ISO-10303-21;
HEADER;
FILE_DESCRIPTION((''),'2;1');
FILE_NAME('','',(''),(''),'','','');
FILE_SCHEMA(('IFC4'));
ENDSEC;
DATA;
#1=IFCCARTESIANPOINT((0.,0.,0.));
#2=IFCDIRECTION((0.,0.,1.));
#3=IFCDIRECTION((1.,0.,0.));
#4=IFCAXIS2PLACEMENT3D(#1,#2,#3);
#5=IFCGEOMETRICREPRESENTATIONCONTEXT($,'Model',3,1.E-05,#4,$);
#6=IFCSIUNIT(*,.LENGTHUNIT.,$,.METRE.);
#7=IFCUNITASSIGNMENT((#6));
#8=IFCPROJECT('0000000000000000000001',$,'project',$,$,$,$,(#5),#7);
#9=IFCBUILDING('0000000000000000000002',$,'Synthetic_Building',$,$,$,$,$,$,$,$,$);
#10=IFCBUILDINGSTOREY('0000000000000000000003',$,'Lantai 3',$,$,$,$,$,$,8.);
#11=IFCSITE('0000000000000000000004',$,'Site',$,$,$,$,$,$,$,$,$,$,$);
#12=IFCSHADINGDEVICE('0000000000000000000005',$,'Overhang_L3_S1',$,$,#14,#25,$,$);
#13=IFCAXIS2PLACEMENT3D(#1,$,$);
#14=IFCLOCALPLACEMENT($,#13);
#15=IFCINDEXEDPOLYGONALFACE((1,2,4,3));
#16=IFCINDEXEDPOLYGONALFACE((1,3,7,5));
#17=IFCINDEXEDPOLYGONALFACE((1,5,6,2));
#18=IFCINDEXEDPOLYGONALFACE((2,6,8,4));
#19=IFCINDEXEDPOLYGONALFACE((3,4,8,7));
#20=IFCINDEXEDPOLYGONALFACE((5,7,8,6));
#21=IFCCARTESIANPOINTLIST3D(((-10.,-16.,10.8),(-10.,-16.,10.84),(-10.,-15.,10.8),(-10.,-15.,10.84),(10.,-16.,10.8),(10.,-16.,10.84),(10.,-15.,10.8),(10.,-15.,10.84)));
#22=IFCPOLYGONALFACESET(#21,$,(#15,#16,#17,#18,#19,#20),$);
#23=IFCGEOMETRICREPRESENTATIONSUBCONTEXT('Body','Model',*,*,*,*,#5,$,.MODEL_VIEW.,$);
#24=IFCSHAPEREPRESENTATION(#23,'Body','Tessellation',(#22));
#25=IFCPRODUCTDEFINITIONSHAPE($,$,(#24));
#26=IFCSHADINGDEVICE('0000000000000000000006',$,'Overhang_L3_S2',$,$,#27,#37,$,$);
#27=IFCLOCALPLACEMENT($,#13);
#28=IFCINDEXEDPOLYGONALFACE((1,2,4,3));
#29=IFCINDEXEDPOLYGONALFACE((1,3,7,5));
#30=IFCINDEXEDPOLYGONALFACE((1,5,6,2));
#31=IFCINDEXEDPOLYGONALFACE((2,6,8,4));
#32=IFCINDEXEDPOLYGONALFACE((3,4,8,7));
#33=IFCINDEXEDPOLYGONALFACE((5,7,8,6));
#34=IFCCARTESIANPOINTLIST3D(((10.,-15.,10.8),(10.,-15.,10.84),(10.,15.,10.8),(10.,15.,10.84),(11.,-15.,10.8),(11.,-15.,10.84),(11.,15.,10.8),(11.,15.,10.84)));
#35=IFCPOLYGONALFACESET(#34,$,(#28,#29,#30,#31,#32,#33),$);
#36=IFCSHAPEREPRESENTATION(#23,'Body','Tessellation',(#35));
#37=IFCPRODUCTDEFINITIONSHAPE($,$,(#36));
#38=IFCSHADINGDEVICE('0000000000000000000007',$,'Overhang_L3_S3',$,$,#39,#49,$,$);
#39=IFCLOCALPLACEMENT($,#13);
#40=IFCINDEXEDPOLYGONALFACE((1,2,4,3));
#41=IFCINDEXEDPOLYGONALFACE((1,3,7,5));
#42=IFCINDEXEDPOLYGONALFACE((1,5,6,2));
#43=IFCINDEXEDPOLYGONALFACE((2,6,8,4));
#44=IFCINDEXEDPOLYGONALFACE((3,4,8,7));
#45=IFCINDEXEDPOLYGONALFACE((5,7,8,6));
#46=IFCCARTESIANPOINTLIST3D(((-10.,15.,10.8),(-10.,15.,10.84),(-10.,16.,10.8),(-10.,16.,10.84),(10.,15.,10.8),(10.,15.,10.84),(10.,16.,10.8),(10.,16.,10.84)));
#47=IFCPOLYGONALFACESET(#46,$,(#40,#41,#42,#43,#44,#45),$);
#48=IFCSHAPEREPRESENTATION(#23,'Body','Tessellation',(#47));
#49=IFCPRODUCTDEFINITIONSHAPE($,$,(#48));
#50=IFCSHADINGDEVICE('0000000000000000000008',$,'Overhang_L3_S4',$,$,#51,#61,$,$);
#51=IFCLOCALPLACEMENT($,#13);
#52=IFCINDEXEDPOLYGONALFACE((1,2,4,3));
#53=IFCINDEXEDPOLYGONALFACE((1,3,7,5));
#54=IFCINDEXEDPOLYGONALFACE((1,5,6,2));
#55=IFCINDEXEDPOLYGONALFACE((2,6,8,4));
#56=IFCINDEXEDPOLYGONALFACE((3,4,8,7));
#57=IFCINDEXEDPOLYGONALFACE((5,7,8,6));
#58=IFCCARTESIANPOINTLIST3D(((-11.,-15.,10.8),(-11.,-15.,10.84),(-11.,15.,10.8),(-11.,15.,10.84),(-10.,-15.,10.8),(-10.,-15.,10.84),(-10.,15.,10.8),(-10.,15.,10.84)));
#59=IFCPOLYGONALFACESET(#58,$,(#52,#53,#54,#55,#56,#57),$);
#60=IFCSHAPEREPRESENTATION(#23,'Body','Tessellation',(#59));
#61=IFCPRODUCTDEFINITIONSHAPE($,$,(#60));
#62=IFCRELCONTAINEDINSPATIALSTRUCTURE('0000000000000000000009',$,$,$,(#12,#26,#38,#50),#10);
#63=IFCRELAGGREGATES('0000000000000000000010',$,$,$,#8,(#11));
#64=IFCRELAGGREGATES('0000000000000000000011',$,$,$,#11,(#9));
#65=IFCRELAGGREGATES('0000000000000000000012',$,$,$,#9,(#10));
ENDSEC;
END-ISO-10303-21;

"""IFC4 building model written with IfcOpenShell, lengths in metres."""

from ifc_helpers import new_model, si_unit, frame, origin_with_axes, place, context, subcontext, project, spatial, polyline, outline, extrude, element, save


model = new_model("IFC4")

# Units and contexts
model_context = context("Model", 3, precision=1e-05, world=origin_with_axes())
body_context = subcontext(model_context, "Body", "Model", "MODEL_VIEW")
ifc_project = project(units=[si_unit("LENGTHUNIT", "METRE")], contexts=[model_context])

# Site, building, storey
site = spatial("IfcSite", under=ifc_project, Name="Site")
building = spatial("IfcBuilding", under=site, Name="Synthetic_Building")
storey = spatial("IfcBuildingStorey", under=building, Name="Lantai 3", Elevation=8.0)

# Shading devices
shading_device_1_placement = place(None, origin_with_axes())
element("IfcShadingDevice", 1, at=shading_device_1_placement, inside=storey, Name="Overhang_L3_S1", context=body_context, shape_type="SweptSolid", body=[
    extrude(outline(polyline([(-10.0, -15.0), (-10.0, -16.0), (10.0, -16.0), (10.0, -15.0), (-10.0, -15.0)])), frame((0.0, 0.0, 10.8), z_axis=(0.0, 0.0, 1.0), x_axis=(1.0, 0.0, 0.0)), (0.0, 0.0, 1.0), 0.04),
])
shading_device_2_placement = place(None, origin_with_axes())
element("IfcShadingDevice", 2, at=shading_device_2_placement, inside=storey, Name="Overhang_L3_S2", context=body_context, shape_type="SweptSolid", body=[
    extrude(outline(polyline([(10.0, -15.0), (11.0, -15.0), (11.0, 15.0), (10.0, 15.0), (10.0, -15.0)])), frame((0.0, 0.0, 10.8), z_axis=(0.0, 0.0, 1.0), x_axis=(1.0, 0.0, 0.0)), (0.0, 0.0, 1.0), 0.04),
])
shading_device_3_placement = place(None, origin_with_axes())
element("IfcShadingDevice", 3, at=shading_device_3_placement, inside=storey, Name="Overhang_L3_S3", context=body_context, shape_type="SweptSolid", body=[
    extrude(outline(polyline([(10.0, 15.0), (10.0, 16.0), (-10.0, 16.0), (-10.0, 15.0), (10.0, 15.0)])), frame((0.0, 0.0, 10.8), z_axis=(0.0, 0.0, 1.0), x_axis=(1.0, 0.0, 0.0)), (0.0, 0.0, 1.0), 0.04),
])
shading_device_4_placement = place(None, origin_with_axes())
element("IfcShadingDevice", 4, at=shading_device_4_placement, inside=storey, Name="Overhang_L3_S4", context=body_context, shape_type="SweptSolid", body=[
    extrude(outline(polyline([(-10.0, 15.0), (-11.0, 15.0), (-11.0, -15.0), (-10.0, -15.0), (-10.0, 15.0)])), frame((0.0, 0.0, 10.8), z_axis=(0.0, 0.0, 1.0), x_axis=(1.0, 0.0, 0.0)), (0.0, 0.0, 1.0), 0.04),
])

save(model, "model.ifc")
